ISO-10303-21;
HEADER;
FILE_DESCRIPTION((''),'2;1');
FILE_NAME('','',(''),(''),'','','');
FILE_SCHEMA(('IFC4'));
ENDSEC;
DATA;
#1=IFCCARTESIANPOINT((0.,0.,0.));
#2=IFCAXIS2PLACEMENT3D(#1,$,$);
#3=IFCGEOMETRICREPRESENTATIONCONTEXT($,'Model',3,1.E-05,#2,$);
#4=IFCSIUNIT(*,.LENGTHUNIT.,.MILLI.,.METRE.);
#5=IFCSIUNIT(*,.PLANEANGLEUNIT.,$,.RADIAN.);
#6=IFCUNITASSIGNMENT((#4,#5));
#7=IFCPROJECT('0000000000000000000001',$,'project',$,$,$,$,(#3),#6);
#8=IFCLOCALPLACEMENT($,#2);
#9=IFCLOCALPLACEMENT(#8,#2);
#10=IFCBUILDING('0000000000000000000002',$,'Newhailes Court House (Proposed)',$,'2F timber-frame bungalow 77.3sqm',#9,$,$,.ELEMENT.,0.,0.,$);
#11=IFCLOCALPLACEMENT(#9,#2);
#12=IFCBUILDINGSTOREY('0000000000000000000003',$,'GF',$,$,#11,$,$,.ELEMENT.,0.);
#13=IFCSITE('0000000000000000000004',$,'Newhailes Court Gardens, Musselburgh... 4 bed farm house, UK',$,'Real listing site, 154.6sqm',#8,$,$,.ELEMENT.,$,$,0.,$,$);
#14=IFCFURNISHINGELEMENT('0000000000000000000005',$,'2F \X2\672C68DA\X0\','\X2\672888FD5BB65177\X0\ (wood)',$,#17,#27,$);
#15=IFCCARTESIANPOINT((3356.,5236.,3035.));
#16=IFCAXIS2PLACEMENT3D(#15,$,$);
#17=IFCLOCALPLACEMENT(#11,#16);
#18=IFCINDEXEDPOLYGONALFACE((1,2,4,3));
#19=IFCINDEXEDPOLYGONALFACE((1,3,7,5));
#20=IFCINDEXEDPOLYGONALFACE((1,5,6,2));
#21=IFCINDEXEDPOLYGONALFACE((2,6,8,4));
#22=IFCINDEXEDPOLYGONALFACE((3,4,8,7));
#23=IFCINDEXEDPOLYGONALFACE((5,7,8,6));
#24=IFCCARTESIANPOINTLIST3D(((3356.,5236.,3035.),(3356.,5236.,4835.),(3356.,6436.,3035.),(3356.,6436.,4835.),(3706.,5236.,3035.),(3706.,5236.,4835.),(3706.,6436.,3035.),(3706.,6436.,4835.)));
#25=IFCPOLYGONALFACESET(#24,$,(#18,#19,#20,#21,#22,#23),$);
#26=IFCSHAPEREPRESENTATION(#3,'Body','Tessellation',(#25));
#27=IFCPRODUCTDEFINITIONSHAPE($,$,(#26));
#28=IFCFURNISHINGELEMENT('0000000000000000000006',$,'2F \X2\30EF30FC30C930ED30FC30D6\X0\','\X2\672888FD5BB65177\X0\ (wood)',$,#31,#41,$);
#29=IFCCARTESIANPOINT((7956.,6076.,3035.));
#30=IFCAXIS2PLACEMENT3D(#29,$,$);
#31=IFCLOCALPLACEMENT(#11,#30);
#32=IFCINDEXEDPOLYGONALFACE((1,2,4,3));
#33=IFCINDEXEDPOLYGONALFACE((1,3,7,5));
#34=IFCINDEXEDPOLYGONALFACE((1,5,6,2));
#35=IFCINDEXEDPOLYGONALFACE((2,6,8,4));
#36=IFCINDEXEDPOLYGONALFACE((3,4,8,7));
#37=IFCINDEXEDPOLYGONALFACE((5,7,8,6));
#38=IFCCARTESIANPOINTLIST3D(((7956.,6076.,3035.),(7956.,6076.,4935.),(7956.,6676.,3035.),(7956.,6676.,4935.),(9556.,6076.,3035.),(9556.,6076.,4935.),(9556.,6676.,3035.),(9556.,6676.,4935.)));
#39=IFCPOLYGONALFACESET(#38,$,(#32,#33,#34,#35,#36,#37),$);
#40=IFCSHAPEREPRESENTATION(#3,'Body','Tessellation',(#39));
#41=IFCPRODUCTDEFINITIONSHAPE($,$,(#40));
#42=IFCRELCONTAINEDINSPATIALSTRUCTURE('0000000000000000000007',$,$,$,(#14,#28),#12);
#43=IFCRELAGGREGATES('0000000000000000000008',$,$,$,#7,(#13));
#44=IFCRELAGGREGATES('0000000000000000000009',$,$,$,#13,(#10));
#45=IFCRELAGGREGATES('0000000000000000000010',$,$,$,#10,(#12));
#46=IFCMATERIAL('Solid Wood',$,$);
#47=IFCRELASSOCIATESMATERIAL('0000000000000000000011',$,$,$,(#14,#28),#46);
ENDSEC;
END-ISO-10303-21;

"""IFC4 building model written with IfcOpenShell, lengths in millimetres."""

from ifc_helpers import new_model, si_unit, frame, frame_2d, origin, place, context, project, spatial, rectangle, extrude, material, element, save


model = new_model("IFC4")

# Units and contexts
model_context = context("Model", 3, precision=1e-05, world=origin())
ifc_project = project(units=[si_unit("LENGTHUNIT", "METRE", prefix="MILLI"), si_unit("PLANEANGLEUNIT", "RADIAN")], contexts=[model_context])

# Site, building, storey
site_placement = place(None, origin())
site = spatial("IfcSite", under=ifc_project, at=site_placement, Name="Newhailes Court Gardens, Musselburgh... 4 bed farm house, UK", ObjectType="Real listing site, 154.6sqm", CompositionType="ELEMENT", RefElevation=0.0)
building_placement = place(site_placement, origin())
building = spatial("IfcBuilding", under=site, at=building_placement, Name="Newhailes Court House (Proposed)", ObjectType="2F timber-frame bungalow 77.3sqm", CompositionType="ELEMENT", ElevationOfRefHeight=0.0, ElevationOfTerrain=0.0)
storey_placement = place(building_placement, origin())
storey = spatial("IfcBuildingStorey", under=building, at=storey_placement, Name="GF", CompositionType="ELEMENT", Elevation=0.0)

# Shared definitions
ifc_material_1 = material(Name="Solid Wood")

# Furnishing elements
furnishing_1_placement = place(storey_placement, frame((3356.0, 5236.0, 3035.0)))
element("IfcFurnishingElement", 1, at=furnishing_1_placement, inside=storey, material=ifc_material_1, Name="2F 本棚", Description="木製家具 (wood)", context=model_context, shape_type="SweptSolid", body=[
    extrude(rectangle(XDim=350.0, YDim=1200.0, at=frame_2d((175.0, 600.0))), frame((3356.0, 5236.0, 3035.0)), (0.0, 0.0, 1.0), 1800.0),
])
furnishing_2_placement = place(storey_placement, frame((7956.0, 6076.0, 3035.0)))
element("IfcFurnishingElement", 2, at=furnishing_2_placement, inside=storey, material=ifc_material_1, Name="2F ワードローブ", Description="木製家具 (wood)", context=model_context, shape_type="SweptSolid", body=[
    extrude(rectangle(XDim=1600.0, YDim=600.0, at=frame_2d((800.0, 300.0))), frame((7956.0, 6076.0, 3035.0)), (0.0, 0.0, 1.0), 1900.0),
])

save(model, "model.ifc")
